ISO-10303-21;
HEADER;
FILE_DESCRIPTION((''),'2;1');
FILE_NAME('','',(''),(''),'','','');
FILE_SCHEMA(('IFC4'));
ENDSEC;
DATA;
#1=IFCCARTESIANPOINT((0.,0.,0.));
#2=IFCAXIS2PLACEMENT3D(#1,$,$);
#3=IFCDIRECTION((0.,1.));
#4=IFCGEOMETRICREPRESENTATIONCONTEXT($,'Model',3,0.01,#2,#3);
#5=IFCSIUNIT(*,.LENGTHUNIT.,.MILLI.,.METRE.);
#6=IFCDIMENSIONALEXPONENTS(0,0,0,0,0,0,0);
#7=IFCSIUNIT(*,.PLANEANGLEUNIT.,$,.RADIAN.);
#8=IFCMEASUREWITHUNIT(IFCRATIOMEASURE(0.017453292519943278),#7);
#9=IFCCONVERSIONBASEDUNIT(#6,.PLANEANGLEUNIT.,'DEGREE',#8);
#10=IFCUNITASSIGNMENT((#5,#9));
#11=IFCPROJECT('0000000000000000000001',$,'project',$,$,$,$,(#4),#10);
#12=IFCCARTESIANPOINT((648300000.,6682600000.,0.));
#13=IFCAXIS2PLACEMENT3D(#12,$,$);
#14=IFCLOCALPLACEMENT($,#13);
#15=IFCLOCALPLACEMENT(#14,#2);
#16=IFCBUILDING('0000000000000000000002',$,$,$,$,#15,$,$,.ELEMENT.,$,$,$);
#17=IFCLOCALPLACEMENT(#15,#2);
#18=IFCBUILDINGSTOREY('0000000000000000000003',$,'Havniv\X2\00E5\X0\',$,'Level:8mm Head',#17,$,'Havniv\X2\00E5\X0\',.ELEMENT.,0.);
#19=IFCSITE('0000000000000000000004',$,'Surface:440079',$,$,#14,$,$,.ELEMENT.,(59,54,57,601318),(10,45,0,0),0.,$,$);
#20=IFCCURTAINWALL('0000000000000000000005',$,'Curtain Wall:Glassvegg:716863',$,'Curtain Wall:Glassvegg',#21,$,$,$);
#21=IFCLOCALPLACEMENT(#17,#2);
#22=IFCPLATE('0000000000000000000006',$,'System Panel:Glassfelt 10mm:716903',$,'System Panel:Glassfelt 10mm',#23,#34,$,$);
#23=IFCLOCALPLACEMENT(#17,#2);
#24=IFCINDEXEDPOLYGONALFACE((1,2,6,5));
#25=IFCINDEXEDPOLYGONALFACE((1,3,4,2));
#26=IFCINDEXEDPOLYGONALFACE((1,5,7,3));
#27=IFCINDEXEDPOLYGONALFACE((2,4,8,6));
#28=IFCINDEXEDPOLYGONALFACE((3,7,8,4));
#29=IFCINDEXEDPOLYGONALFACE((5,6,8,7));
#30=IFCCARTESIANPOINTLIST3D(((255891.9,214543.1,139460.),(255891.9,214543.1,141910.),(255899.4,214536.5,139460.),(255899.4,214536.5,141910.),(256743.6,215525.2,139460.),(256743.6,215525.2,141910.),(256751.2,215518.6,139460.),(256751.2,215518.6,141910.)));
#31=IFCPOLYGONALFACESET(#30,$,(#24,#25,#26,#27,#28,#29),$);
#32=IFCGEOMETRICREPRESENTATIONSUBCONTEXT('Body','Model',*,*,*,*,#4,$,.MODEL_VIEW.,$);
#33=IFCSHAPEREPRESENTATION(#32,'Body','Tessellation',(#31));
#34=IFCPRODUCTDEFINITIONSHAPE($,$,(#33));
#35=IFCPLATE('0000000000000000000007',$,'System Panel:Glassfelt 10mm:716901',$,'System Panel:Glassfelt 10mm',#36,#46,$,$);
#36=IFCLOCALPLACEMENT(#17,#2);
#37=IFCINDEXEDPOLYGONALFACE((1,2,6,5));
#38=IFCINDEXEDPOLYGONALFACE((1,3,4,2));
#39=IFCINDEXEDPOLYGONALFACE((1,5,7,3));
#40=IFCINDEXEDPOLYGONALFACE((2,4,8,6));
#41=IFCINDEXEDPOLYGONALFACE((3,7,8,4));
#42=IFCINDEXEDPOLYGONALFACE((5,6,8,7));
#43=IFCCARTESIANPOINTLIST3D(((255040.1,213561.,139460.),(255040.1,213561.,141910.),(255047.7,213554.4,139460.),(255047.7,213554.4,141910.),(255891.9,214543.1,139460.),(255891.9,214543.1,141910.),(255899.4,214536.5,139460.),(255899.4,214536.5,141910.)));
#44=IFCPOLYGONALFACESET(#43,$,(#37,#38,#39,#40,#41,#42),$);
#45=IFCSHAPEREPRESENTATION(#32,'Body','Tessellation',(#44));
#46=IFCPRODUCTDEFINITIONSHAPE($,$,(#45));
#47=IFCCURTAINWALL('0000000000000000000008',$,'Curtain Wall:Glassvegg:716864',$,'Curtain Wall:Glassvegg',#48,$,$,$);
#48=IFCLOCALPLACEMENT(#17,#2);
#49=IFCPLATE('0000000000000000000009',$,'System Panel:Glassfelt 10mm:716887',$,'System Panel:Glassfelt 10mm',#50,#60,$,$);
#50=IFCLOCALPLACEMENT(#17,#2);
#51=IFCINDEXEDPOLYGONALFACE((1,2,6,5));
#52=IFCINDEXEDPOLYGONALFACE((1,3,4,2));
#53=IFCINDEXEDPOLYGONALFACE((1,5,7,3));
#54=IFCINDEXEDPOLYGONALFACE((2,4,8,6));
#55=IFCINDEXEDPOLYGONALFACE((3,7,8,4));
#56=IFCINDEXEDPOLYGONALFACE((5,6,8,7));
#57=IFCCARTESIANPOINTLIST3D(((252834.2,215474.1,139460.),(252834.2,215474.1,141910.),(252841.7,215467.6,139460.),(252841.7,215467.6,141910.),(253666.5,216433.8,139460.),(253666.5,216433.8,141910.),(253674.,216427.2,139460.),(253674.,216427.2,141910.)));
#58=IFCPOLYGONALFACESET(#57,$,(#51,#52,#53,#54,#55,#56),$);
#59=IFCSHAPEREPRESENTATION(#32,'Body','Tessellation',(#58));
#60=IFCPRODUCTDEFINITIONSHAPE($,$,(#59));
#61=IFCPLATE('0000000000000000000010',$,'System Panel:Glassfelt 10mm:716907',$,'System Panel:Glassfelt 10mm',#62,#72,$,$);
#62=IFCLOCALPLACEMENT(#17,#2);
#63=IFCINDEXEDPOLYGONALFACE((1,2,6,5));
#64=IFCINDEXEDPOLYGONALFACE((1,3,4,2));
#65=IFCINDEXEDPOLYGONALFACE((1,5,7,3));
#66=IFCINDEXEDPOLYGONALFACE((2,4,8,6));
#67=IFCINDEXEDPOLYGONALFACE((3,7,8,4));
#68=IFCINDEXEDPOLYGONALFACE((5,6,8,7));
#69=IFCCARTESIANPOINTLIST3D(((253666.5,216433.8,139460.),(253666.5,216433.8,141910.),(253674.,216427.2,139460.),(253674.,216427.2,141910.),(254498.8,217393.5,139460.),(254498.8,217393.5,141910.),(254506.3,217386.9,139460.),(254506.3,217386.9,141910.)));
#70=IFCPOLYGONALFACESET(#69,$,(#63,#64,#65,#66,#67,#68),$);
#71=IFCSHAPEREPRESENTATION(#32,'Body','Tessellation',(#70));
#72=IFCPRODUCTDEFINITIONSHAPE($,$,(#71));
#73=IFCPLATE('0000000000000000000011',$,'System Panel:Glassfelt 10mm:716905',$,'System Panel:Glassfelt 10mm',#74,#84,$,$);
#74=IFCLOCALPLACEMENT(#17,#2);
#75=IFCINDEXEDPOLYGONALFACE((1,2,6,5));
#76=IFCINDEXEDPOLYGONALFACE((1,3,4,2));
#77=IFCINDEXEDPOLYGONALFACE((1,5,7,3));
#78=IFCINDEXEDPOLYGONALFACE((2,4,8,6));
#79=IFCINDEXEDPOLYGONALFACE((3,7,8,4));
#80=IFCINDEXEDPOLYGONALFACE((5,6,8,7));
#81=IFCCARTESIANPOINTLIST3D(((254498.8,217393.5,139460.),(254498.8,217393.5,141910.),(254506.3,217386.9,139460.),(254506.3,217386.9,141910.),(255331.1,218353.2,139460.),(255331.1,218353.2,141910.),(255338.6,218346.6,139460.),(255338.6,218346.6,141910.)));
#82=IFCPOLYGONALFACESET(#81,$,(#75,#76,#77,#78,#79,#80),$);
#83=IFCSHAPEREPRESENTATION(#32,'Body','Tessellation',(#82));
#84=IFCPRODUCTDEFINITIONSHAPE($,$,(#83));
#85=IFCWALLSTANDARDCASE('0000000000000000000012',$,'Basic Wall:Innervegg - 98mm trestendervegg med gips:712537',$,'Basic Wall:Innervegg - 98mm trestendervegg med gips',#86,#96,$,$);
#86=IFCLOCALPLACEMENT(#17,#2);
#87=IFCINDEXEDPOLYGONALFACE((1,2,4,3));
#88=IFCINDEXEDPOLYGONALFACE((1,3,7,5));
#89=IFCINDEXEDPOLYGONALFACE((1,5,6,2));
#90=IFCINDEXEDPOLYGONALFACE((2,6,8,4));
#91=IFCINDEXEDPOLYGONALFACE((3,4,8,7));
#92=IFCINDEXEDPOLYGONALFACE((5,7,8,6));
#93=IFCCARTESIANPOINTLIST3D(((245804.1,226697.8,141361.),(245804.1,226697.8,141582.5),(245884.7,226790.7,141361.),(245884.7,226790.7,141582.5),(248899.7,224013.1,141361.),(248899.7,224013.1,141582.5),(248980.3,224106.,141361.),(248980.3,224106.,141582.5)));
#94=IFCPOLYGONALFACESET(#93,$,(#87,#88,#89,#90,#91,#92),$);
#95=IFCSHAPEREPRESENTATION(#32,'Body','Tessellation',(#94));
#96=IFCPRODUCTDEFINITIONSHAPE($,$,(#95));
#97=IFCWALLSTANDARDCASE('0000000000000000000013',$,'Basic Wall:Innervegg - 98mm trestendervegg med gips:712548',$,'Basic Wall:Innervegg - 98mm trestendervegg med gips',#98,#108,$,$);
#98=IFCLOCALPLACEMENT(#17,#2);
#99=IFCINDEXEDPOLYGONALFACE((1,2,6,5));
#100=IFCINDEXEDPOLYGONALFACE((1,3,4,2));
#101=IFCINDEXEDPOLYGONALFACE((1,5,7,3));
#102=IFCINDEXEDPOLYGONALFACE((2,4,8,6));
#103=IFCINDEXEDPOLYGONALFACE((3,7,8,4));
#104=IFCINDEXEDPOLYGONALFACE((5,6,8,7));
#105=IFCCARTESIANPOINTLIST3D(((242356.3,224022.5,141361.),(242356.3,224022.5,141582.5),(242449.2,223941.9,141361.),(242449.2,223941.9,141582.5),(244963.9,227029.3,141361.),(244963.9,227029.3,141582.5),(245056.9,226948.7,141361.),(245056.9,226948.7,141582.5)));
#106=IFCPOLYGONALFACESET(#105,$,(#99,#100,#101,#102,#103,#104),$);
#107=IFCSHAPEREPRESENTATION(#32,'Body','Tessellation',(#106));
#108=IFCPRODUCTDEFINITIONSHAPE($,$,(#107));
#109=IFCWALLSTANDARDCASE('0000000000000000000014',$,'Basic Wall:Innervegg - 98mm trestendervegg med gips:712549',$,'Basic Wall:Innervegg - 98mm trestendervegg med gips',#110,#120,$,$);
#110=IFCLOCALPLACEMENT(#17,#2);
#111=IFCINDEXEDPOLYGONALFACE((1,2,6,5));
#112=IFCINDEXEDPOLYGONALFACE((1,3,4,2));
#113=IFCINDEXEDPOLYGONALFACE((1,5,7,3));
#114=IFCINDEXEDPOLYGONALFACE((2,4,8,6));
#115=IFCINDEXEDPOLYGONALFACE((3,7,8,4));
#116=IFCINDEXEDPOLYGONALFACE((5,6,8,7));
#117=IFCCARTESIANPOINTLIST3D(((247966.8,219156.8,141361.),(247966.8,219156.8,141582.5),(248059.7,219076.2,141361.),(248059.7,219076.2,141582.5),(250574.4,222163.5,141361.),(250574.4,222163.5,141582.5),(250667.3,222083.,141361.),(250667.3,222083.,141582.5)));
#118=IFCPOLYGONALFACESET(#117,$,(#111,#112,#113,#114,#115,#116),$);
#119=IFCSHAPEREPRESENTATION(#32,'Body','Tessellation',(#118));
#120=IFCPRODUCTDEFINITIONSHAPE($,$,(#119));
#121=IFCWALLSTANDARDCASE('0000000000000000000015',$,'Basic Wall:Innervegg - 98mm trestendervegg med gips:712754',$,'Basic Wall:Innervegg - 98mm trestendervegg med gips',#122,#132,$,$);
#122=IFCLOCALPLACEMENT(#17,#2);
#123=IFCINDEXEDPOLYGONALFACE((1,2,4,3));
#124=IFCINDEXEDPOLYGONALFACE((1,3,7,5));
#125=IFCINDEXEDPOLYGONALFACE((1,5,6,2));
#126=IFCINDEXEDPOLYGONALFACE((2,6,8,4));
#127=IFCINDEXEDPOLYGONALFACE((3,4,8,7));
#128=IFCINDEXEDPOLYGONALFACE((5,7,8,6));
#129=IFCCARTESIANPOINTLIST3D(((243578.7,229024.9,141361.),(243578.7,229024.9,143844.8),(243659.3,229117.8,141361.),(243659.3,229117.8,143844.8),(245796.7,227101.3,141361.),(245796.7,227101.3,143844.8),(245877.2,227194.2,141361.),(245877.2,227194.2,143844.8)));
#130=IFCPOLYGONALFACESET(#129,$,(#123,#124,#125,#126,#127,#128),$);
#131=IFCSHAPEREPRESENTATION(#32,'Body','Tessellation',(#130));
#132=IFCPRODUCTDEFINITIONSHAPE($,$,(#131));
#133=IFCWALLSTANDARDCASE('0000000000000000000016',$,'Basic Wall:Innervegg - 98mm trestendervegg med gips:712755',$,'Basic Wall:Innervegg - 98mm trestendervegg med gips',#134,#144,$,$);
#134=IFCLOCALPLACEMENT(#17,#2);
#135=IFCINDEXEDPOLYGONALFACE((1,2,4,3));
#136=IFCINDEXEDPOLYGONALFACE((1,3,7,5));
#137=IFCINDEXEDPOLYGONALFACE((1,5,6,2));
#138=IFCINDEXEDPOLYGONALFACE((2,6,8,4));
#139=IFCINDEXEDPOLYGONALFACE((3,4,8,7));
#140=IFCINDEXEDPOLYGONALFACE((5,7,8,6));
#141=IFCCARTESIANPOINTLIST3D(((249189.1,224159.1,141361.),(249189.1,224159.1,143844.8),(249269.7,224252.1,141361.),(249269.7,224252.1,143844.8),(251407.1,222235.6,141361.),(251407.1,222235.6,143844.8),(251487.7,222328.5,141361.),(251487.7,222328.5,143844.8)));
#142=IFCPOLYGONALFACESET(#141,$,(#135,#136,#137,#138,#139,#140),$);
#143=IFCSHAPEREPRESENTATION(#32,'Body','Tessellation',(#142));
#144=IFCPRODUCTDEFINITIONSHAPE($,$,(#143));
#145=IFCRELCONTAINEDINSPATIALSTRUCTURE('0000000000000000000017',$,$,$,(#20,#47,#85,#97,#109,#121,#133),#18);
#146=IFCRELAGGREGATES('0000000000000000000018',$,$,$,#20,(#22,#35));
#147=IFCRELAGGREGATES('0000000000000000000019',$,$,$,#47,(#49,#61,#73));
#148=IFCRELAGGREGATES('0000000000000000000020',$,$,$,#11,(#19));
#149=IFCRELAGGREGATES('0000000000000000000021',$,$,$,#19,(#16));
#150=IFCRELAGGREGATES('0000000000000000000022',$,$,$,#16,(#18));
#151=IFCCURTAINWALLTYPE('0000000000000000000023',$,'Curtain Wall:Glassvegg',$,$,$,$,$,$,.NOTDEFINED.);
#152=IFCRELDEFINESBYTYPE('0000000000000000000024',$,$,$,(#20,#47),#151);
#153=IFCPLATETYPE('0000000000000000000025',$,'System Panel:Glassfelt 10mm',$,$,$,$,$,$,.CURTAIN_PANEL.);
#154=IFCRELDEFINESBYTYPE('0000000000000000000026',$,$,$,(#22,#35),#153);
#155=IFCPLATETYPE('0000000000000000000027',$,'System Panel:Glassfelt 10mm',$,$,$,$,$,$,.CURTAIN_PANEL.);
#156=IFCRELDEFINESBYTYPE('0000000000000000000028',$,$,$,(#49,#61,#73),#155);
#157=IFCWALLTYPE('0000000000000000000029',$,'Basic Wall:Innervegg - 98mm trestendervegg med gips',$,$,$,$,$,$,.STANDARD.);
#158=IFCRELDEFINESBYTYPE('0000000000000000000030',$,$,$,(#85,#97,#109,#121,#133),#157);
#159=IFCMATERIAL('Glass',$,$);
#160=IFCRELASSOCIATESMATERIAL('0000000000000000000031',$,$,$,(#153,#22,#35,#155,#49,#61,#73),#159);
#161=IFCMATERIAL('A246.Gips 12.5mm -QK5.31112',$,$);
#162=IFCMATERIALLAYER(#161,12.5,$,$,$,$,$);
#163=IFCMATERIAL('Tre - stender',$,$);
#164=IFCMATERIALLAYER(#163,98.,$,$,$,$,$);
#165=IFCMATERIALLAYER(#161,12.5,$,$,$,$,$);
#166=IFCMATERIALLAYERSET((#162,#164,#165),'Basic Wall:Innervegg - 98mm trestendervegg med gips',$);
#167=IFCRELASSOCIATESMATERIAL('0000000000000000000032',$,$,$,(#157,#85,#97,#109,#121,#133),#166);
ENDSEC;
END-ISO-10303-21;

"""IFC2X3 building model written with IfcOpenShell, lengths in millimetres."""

from ifc_helpers import new_model, entity, si_unit, converted_unit, direction, frame, frame_2d, origin, place, context, subcontext, project, spatial, rectangle, extrude, source, transform, mapped, material, layer, layer_set, layer_usage, type_object, type_shapes, element, aggregate, save


model = new_model("IFC2X3")

# Units and contexts
model_context = context("Model", 3, precision=0.01, world=origin(), true_north=direction((0.0, 1.0)))
body_context = subcontext(model_context, "Body", "Model", "MODEL_VIEW")
ifc_project = project(units=[si_unit("LENGTHUNIT", "METRE", prefix="MILLI"), converted_unit("PLANEANGLEUNIT", "DEGREE", entity("IfcRatioMeasure", 0.017453292519943278), si_unit("PLANEANGLEUNIT", "RADIAN"), dimensions=[0, 0, 0, 0, 0, 0, 0])], contexts=[model_context])

# Site, building, storey
site_placement = place(None, frame((648300000.0, 6682600000.0, 0.0)))
site = spatial("IfcSite", under=ifc_project, at=site_placement, Name="Surface:440079", CompositionType="ELEMENT", RefLatitude=(59, 54, 57, 601318), RefLongitude=(10, 45, 0, 0), RefElevation=0.0)
building_placement = place(site_placement, origin())
building = spatial("IfcBuilding", under=site, at=building_placement, CompositionType="ELEMENT")
storey_placement = place(building_placement, origin())
storey = spatial("IfcBuildingStorey", under=building, at=storey_placement, Name="Havnivå", ObjectType="Level:8mm Head", LongName="Havnivå", CompositionType="ELEMENT", Elevation=0.0)

# Curtain walls, plates
curtain_wall_type = type_object("IfcCurtainWallType", Name="Curtain Wall:Glassvegg", PredefinedType="NOTDEFINED")
curtain_wall_1_placement = place(storey_placement, origin())
curtain_wall_1 = element("IfcCurtainWall", 1, at=curtain_wall_1_placement, inside=storey, type_object=curtain_wall_type, Name="Curtain Wall:Glassvegg:716863", ObjectType="Curtain Wall:Glassvegg")
ifc_material_1 = material(Name="Glass")
plate_type_1 = type_object("IfcPlateType", Name="System Panel:Glassfelt 10mm", PredefinedType="CURTAIN_PANEL", material=ifc_material_1)
shared_shape_1 = source(origin(), body_context, "Body", "SweptSolid", [
    extrude(rectangle(XDim=10.0, YDim=1300.0, at=frame_2d((0.0, 0.0), x_axis=(1.0, 0.0))), frame((0.0, 10.0, 0.0), z_axis=(0.0, 0.0, 1.0), x_axis=(0.0, 1.0, 0.0)), (0.0, 0.0, 1.0), 2450.0),
])
type_shapes(plate_type_1, [shared_shape_1])
plate_1_placement = place(curtain_wall_1_placement, frame((256314.0, 215037.4, 139460.0), z_axis=(0.0, 0.0, 1.0), x_axis=(-0.655187, -0.755467, 0.0)))
plate_1 = element("IfcPlate", 2, at=plate_1_placement, type_object=plate_type_1, material=ifc_material_1, Name="System Panel:Glassfelt 10mm:716903", ObjectType="System Panel:Glassfelt 10mm", context=body_context, shape_type="MappedRepresentation", body=[
    mapped(shared_shape_1, transform((0.0, 0.0, 0.0), scale=1.0)),
])
plate_2_placement = place(curtain_wall_1_placement, frame((255462.2, 214055.3, 139460.0), z_axis=(0.0, 0.0, 1.0), x_axis=(-0.655187, -0.755467, 0.0)))
plate_2 = element("IfcPlate", 3, at=plate_2_placement, type_object=plate_type_1, material=ifc_material_1, Name="System Panel:Glassfelt 10mm:716901", ObjectType="System Panel:Glassfelt 10mm", context=body_context, shape_type="MappedRepresentation", body=[
    mapped(shared_shape_1, transform((0.0, 0.0, 0.0), scale=1.0)),
])
aggregate(curtain_wall_1, [plate_1, plate_2])
curtain_wall_2_placement = place(storey_placement, origin())
curtain_wall_2 = element("IfcCurtainWall", 4, at=curtain_wall_2_placement, inside=storey, type_object=curtain_wall_type, Name="Curtain Wall:Glassvegg:716864", ObjectType="Curtain Wall:Glassvegg")
plate_type_2 = type_object("IfcPlateType", Name="System Panel:Glassfelt 10mm", PredefinedType="CURTAIN_PANEL", material=ifc_material_1)
shared_shape_2 = source(origin(), body_context, "Body", "SweptSolid", [
    extrude(rectangle(XDim=10.0, YDim=1270.3, at=frame_2d((0.0, 0.0), x_axis=(1.0, 0.0))), frame((0.0, 10.0, 0.0), z_axis=(0.0, 0.0, 1.0), x_axis=(0.0, 1.0, 0.0)), (0.0, 0.0, 1.0), 2450.0),
])
type_shapes(plate_type_2, [shared_shape_2])
plate_3_placement = place(curtain_wall_2_placement, frame((253261.7, 215944.1, 139460.0), z_axis=(0.0, 0.0, 1.0), x_axis=(0.655187, 0.755467, 0.0)))
plate_3 = element("IfcPlate", 5, at=plate_3_placement, type_object=plate_type_2, material=ifc_material_1, Name="System Panel:Glassfelt 10mm:716887", ObjectType="System Panel:Glassfelt 10mm", context=body_context, shape_type="MappedRepresentation", body=[
    mapped(shared_shape_2, transform((0.0, 0.0, 0.0), scale=1.0)),
])
plate_4_placement = place(curtain_wall_2_placement, frame((254094.0, 216903.8, 139460.0), z_axis=(0.0, 0.0, 1.0), x_axis=(0.655187, 0.755467, 0.0)))
plate_4 = element("IfcPlate", 6, at=plate_4_placement, type_object=plate_type_2, material=ifc_material_1, Name="System Panel:Glassfelt 10mm:716907", ObjectType="System Panel:Glassfelt 10mm", context=body_context, shape_type="MappedRepresentation", body=[
    mapped(shared_shape_2, transform((0.0, 0.0, 0.0), scale=1.0)),
])
plate_5_placement = place(curtain_wall_2_placement, frame((254926.3, 217863.5, 139460.0), z_axis=(0.0, 0.0, 1.0), x_axis=(0.655187, 0.755467, 0.0)))
plate_5 = element("IfcPlate", 7, at=plate_5_placement, type_object=plate_type_2, material=ifc_material_1, Name="System Panel:Glassfelt 10mm:716905", ObjectType="System Panel:Glassfelt 10mm", context=body_context, shape_type="MappedRepresentation", body=[
    mapped(shared_shape_2, transform((0.0, 0.0, 0.0), scale=1.0)),
])
aggregate(curtain_wall_2, [plate_3, plate_4, plate_5])

# Walls
ifc_material_2 = material(Name="A246.Gips 12.5mm -QK5.31112")
ifc_layer_1 = layer(ifc_material_2, 12.5)
ifc_material_3 = material(Name="Tre - stender")
ifc_layer_2 = layer(ifc_material_3, 98.0)
ifc_layer_3 = layer(ifc_material_2, 12.5)
ifc_layer_set = layer_set([ifc_layer_1, ifc_layer_2, ifc_layer_3], Name="Basic Wall:Innervegg - 98mm trestendervegg med gips")
ifc_layer_usage_1 = layer_usage(ifc_layer_set, "AXIS2", "NEGATIVE", 61.5)
wall_type = type_object("IfcWallType", Name="Basic Wall:Innervegg - 98mm trestendervegg med gips", PredefinedType="STANDARD", material=ifc_layer_set)
wall_1_placement = place(storey_placement, frame((248940.0, 224059.5, 141361.0), z_axis=(0.0, 0.0, 1.0), x_axis=(-0.755467, 0.655187, 0.0)))
element("IfcWallStandardCase", 8, at=wall_1_placement, inside=storey, type_object=wall_type, material=ifc_layer_usage_1, Name="Basic Wall:Innervegg - 98mm trestendervegg med gips:712537", ObjectType="Basic Wall:Innervegg - 98mm trestendervegg med gips", context=body_context, shape_type="SweptSolid", body=[
    extrude(rectangle(XDim=4097.6, YDim=123.0, at=frame_2d((2048.8, 0.0), x_axis=(-1.0, 0.0))), origin(), (0.0, 0.0, 1.0), 221.5),
])
ifc_layer_usage_2 = layer_usage(ifc_layer_set, "AXIS2", "NEGATIVE", 61.5)
wall_2_placement = place(storey_placement, frame((242402.7, 223982.2, 141361.0), z_axis=(0.0, 0.0, 1.0), x_axis=(0.655187, 0.755467, 0.0)))
element("IfcWallStandardCase", 9, at=wall_2_placement, inside=storey, type_object=wall_type, material=ifc_layer_usage_2, Name="Basic Wall:Innervegg - 98mm trestendervegg med gips:712548", ObjectType="Basic Wall:Innervegg - 98mm trestendervegg med gips", context=body_context, shape_type="SweptSolid", body=[
    extrude(rectangle(XDim=3980.0, YDim=123.0, at=frame_2d((1990.0, 0.0), x_axis=(-1.0, 0.0))), origin(), (0.0, 0.0, 1.0), 221.5),
])
ifc_layer_usage_3 = layer_usage(ifc_layer_set, "AXIS2", "NEGATIVE", 61.5)
wall_3_placement = place(storey_placement, frame((248013.2, 219116.5, 141361.0), z_axis=(0.0, 0.0, 1.0), x_axis=(0.655187, 0.755467, 0.0)))
element("IfcWallStandardCase", 10, at=wall_3_placement, inside=storey, type_object=wall_type, material=ifc_layer_usage_3, Name="Basic Wall:Innervegg - 98mm trestendervegg med gips:712549", ObjectType="Basic Wall:Innervegg - 98mm trestendervegg med gips", context=body_context, shape_type="SweptSolid", body=[
    extrude(rectangle(XDim=3980.0, YDim=123.0, at=frame_2d((1990.0, 0.0), x_axis=(-1.0, 0.0))), origin(), (0.0, 0.0, 1.0), 221.5),
])
ifc_layer_usage_4 = layer_usage(ifc_layer_set, "AXIS2", "NEGATIVE", 61.5)
wall_4_placement = place(storey_placement, frame((245836.9, 227147.8, 141361.0), z_axis=(0.0, 0.0, 1.0), x_axis=(-0.755467, 0.655187, 0.0)))
element("IfcWallStandardCase", 11, at=wall_4_placement, inside=storey, type_object=wall_type, material=ifc_layer_usage_4, Name="Basic Wall:Innervegg - 98mm trestendervegg med gips:712754", ObjectType="Basic Wall:Innervegg - 98mm trestendervegg med gips", context=body_context, shape_type="SweptSolid", body=[
    extrude(rectangle(XDim=2935.9, YDim=123.0, at=frame_2d((1468.0, 0.0), x_axis=(-1.0, 0.0))), origin(), (0.0, 0.0, 1.0), 2483.8),
])
ifc_layer_usage_5 = layer_usage(ifc_layer_set, "AXIS2", "NEGATIVE", 61.5)
wall_5_placement = place(storey_placement, frame((251447.4, 222282.0, 141361.0), z_axis=(0.0, 0.0, 1.0), x_axis=(-0.755467, 0.655187, 0.0)))
element("IfcWallStandardCase", 12, at=wall_5_placement, inside=storey, type_object=wall_type, material=ifc_layer_usage_5, Name="Basic Wall:Innervegg - 98mm trestendervegg med gips:712755", ObjectType="Basic Wall:Innervegg - 98mm trestendervegg med gips", context=body_context, shape_type="SweptSolid", body=[
    extrude(rectangle(XDim=2935.9, YDim=123.0, at=frame_2d((1468.0, 0.0), x_axis=(-1.0, 0.0))), origin(), (0.0, 0.0, 1.0), 2483.8),
])

save(model, "model.ifc")
